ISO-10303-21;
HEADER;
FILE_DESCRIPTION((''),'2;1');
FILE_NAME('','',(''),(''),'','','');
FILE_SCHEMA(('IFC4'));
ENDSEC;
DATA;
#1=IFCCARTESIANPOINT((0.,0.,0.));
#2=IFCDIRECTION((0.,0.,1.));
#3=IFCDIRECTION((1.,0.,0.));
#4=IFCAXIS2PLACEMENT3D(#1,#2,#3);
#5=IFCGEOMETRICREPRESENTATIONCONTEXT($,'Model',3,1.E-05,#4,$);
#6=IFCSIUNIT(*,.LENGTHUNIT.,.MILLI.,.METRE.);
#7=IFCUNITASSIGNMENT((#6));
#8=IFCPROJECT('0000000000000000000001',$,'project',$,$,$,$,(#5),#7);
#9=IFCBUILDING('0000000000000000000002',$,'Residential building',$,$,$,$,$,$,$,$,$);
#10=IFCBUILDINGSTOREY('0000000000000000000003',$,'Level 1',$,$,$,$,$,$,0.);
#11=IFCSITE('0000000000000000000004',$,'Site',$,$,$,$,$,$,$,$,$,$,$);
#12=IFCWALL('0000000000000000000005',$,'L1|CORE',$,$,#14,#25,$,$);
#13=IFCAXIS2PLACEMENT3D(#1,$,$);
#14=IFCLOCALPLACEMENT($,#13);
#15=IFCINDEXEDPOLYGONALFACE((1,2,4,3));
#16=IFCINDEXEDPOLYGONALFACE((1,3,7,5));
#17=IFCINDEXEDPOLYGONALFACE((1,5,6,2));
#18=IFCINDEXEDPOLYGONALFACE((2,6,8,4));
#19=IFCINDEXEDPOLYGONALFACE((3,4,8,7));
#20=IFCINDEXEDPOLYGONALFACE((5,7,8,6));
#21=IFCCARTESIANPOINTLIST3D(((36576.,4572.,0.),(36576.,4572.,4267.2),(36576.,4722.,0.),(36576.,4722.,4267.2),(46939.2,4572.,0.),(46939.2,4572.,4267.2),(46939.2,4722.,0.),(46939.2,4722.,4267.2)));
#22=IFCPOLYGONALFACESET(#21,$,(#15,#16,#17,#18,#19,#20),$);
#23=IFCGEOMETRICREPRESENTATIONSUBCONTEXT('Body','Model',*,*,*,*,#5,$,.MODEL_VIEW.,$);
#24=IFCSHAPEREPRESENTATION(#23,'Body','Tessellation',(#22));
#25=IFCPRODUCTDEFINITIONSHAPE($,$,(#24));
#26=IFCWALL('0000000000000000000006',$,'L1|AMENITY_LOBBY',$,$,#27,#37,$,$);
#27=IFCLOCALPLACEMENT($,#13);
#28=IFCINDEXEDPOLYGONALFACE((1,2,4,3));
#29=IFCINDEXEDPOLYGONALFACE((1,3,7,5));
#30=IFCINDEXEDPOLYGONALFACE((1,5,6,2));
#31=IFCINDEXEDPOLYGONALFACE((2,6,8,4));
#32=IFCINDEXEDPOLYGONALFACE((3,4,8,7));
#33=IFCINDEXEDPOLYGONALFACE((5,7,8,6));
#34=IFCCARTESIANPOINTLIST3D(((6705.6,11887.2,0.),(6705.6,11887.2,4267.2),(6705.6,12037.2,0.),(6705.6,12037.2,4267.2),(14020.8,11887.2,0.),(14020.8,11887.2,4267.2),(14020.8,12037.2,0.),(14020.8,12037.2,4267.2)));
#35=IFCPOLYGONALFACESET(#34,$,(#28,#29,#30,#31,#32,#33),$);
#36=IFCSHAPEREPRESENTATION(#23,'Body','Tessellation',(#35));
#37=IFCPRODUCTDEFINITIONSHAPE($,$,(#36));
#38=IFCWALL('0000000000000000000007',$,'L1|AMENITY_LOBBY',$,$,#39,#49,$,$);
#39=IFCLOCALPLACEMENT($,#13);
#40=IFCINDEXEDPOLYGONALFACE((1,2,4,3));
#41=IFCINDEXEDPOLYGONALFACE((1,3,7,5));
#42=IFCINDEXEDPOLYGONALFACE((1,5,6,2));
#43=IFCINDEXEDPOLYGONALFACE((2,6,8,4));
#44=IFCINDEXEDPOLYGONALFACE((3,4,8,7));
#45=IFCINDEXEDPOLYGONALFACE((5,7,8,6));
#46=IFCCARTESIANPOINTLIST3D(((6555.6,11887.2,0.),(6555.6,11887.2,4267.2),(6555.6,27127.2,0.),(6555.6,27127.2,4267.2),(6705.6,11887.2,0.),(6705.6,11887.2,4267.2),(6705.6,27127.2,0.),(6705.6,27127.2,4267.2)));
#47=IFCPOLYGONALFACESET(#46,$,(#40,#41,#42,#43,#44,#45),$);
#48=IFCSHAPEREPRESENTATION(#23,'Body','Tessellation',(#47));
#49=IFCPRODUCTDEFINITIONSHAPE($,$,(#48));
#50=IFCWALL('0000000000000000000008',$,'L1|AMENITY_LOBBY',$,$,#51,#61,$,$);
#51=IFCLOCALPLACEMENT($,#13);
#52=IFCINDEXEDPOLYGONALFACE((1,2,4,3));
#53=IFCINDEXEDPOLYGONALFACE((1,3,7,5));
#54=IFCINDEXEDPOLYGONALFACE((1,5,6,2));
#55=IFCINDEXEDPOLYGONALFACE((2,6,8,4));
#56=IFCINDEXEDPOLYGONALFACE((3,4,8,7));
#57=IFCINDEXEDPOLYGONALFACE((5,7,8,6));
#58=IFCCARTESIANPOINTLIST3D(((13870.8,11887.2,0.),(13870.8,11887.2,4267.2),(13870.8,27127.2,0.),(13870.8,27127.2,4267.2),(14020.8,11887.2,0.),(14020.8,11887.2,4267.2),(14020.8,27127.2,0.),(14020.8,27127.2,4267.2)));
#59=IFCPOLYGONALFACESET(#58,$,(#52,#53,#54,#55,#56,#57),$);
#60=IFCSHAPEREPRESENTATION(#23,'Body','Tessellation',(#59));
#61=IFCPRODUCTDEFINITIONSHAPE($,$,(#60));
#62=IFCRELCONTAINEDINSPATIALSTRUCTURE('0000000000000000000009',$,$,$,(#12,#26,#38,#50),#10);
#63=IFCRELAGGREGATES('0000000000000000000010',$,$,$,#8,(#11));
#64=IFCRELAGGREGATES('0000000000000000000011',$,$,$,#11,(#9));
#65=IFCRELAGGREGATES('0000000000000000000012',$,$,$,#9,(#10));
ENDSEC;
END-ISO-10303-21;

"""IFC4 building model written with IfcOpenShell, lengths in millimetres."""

from ifc_helpers import new_model, si_unit, frame, origin_with_axes, place, context, subcontext, project, spatial, indexed_curve, outline, extrude, element, save


model = new_model("IFC4")

# Units and contexts
model_context = context("Model", 3, precision=1e-05, world=origin_with_axes())
body_context = subcontext(model_context, "Body", "Model", "MODEL_VIEW")
ifc_project = project(units=[si_unit("LENGTHUNIT", "METRE", prefix="MILLI")], contexts=[model_context])

# Site, building, storey
site = spatial("IfcSite", under=ifc_project, Name="Site")
building = spatial("IfcBuilding", under=site, Name="Residential building")
storey = spatial("IfcBuildingStorey", under=building, Name="Level 1", Elevation=0.0)

# Walls
wall_1_placement = place(None, frame((36576.0, 4572.0, 0.0), z_axis=(0.0, 0.0, 1.0), x_axis=(1.0, 0.0, 0.0)))
element("IfcWall", 1, at=wall_1_placement, inside=storey, Name="L1|CORE", context=body_context, shape_type="SweptSolid", body=[
    extrude(outline(indexed_curve([(0.0, 0.0), (0.0, 150.0), (10363.2, 150.0), (10363.2, 0.0), (0.0, 0.0)], self_intersect=False)), origin_with_axes(), (0.0, 0.0, 1.0), 4267.2),
])
wall_2_placement = place(None, frame((6705.6, 11887.2, 0.0), z_axis=(0.0, 0.0, 1.0), x_axis=(1.0, 0.0, 0.0)))
element("IfcWall", 2, at=wall_2_placement, inside=storey, Name="L1|AMENITY_LOBBY", context=body_context, shape_type="SweptSolid", body=[
    extrude(outline(indexed_curve([(0.0, 0.0), (0.0, 150.0), (7315.2, 150.0), (7315.2, 0.0), (0.0, 0.0)], self_intersect=False)), origin_with_axes(), (0.0, 0.0, 1.0), 4267.2),
])
for number, where, z_axis, x_axis, name in (
    (3, (6705.6, 11887.2, 0.0), (0.0, 0.0, 1.0), (0.0, 1.0, 0.0), "L1|AMENITY_LOBBY"),
    (4, (14020.8, 11887.2, 0.0), (0.0, 0.0, 1.0), (0.0, 1.0, 0.0), "L1|AMENITY_LOBBY"),
):
    element("IfcWall", number, at=place(None, frame(where, z_axis=z_axis, x_axis=x_axis)), inside=storey, Name=name, context=body_context, shape_type="SweptSolid", body=[
        extrude(outline(indexed_curve([(0.0, 0.0), (0.0, 150.0), (15240.0, 150.0), (15240.0, 0.0), (0.0, 0.0)], self_intersect=False)), origin_with_axes(), (0.0, 0.0, 1.0), 4267.2),
    ])

save(model, "model.ifc")
